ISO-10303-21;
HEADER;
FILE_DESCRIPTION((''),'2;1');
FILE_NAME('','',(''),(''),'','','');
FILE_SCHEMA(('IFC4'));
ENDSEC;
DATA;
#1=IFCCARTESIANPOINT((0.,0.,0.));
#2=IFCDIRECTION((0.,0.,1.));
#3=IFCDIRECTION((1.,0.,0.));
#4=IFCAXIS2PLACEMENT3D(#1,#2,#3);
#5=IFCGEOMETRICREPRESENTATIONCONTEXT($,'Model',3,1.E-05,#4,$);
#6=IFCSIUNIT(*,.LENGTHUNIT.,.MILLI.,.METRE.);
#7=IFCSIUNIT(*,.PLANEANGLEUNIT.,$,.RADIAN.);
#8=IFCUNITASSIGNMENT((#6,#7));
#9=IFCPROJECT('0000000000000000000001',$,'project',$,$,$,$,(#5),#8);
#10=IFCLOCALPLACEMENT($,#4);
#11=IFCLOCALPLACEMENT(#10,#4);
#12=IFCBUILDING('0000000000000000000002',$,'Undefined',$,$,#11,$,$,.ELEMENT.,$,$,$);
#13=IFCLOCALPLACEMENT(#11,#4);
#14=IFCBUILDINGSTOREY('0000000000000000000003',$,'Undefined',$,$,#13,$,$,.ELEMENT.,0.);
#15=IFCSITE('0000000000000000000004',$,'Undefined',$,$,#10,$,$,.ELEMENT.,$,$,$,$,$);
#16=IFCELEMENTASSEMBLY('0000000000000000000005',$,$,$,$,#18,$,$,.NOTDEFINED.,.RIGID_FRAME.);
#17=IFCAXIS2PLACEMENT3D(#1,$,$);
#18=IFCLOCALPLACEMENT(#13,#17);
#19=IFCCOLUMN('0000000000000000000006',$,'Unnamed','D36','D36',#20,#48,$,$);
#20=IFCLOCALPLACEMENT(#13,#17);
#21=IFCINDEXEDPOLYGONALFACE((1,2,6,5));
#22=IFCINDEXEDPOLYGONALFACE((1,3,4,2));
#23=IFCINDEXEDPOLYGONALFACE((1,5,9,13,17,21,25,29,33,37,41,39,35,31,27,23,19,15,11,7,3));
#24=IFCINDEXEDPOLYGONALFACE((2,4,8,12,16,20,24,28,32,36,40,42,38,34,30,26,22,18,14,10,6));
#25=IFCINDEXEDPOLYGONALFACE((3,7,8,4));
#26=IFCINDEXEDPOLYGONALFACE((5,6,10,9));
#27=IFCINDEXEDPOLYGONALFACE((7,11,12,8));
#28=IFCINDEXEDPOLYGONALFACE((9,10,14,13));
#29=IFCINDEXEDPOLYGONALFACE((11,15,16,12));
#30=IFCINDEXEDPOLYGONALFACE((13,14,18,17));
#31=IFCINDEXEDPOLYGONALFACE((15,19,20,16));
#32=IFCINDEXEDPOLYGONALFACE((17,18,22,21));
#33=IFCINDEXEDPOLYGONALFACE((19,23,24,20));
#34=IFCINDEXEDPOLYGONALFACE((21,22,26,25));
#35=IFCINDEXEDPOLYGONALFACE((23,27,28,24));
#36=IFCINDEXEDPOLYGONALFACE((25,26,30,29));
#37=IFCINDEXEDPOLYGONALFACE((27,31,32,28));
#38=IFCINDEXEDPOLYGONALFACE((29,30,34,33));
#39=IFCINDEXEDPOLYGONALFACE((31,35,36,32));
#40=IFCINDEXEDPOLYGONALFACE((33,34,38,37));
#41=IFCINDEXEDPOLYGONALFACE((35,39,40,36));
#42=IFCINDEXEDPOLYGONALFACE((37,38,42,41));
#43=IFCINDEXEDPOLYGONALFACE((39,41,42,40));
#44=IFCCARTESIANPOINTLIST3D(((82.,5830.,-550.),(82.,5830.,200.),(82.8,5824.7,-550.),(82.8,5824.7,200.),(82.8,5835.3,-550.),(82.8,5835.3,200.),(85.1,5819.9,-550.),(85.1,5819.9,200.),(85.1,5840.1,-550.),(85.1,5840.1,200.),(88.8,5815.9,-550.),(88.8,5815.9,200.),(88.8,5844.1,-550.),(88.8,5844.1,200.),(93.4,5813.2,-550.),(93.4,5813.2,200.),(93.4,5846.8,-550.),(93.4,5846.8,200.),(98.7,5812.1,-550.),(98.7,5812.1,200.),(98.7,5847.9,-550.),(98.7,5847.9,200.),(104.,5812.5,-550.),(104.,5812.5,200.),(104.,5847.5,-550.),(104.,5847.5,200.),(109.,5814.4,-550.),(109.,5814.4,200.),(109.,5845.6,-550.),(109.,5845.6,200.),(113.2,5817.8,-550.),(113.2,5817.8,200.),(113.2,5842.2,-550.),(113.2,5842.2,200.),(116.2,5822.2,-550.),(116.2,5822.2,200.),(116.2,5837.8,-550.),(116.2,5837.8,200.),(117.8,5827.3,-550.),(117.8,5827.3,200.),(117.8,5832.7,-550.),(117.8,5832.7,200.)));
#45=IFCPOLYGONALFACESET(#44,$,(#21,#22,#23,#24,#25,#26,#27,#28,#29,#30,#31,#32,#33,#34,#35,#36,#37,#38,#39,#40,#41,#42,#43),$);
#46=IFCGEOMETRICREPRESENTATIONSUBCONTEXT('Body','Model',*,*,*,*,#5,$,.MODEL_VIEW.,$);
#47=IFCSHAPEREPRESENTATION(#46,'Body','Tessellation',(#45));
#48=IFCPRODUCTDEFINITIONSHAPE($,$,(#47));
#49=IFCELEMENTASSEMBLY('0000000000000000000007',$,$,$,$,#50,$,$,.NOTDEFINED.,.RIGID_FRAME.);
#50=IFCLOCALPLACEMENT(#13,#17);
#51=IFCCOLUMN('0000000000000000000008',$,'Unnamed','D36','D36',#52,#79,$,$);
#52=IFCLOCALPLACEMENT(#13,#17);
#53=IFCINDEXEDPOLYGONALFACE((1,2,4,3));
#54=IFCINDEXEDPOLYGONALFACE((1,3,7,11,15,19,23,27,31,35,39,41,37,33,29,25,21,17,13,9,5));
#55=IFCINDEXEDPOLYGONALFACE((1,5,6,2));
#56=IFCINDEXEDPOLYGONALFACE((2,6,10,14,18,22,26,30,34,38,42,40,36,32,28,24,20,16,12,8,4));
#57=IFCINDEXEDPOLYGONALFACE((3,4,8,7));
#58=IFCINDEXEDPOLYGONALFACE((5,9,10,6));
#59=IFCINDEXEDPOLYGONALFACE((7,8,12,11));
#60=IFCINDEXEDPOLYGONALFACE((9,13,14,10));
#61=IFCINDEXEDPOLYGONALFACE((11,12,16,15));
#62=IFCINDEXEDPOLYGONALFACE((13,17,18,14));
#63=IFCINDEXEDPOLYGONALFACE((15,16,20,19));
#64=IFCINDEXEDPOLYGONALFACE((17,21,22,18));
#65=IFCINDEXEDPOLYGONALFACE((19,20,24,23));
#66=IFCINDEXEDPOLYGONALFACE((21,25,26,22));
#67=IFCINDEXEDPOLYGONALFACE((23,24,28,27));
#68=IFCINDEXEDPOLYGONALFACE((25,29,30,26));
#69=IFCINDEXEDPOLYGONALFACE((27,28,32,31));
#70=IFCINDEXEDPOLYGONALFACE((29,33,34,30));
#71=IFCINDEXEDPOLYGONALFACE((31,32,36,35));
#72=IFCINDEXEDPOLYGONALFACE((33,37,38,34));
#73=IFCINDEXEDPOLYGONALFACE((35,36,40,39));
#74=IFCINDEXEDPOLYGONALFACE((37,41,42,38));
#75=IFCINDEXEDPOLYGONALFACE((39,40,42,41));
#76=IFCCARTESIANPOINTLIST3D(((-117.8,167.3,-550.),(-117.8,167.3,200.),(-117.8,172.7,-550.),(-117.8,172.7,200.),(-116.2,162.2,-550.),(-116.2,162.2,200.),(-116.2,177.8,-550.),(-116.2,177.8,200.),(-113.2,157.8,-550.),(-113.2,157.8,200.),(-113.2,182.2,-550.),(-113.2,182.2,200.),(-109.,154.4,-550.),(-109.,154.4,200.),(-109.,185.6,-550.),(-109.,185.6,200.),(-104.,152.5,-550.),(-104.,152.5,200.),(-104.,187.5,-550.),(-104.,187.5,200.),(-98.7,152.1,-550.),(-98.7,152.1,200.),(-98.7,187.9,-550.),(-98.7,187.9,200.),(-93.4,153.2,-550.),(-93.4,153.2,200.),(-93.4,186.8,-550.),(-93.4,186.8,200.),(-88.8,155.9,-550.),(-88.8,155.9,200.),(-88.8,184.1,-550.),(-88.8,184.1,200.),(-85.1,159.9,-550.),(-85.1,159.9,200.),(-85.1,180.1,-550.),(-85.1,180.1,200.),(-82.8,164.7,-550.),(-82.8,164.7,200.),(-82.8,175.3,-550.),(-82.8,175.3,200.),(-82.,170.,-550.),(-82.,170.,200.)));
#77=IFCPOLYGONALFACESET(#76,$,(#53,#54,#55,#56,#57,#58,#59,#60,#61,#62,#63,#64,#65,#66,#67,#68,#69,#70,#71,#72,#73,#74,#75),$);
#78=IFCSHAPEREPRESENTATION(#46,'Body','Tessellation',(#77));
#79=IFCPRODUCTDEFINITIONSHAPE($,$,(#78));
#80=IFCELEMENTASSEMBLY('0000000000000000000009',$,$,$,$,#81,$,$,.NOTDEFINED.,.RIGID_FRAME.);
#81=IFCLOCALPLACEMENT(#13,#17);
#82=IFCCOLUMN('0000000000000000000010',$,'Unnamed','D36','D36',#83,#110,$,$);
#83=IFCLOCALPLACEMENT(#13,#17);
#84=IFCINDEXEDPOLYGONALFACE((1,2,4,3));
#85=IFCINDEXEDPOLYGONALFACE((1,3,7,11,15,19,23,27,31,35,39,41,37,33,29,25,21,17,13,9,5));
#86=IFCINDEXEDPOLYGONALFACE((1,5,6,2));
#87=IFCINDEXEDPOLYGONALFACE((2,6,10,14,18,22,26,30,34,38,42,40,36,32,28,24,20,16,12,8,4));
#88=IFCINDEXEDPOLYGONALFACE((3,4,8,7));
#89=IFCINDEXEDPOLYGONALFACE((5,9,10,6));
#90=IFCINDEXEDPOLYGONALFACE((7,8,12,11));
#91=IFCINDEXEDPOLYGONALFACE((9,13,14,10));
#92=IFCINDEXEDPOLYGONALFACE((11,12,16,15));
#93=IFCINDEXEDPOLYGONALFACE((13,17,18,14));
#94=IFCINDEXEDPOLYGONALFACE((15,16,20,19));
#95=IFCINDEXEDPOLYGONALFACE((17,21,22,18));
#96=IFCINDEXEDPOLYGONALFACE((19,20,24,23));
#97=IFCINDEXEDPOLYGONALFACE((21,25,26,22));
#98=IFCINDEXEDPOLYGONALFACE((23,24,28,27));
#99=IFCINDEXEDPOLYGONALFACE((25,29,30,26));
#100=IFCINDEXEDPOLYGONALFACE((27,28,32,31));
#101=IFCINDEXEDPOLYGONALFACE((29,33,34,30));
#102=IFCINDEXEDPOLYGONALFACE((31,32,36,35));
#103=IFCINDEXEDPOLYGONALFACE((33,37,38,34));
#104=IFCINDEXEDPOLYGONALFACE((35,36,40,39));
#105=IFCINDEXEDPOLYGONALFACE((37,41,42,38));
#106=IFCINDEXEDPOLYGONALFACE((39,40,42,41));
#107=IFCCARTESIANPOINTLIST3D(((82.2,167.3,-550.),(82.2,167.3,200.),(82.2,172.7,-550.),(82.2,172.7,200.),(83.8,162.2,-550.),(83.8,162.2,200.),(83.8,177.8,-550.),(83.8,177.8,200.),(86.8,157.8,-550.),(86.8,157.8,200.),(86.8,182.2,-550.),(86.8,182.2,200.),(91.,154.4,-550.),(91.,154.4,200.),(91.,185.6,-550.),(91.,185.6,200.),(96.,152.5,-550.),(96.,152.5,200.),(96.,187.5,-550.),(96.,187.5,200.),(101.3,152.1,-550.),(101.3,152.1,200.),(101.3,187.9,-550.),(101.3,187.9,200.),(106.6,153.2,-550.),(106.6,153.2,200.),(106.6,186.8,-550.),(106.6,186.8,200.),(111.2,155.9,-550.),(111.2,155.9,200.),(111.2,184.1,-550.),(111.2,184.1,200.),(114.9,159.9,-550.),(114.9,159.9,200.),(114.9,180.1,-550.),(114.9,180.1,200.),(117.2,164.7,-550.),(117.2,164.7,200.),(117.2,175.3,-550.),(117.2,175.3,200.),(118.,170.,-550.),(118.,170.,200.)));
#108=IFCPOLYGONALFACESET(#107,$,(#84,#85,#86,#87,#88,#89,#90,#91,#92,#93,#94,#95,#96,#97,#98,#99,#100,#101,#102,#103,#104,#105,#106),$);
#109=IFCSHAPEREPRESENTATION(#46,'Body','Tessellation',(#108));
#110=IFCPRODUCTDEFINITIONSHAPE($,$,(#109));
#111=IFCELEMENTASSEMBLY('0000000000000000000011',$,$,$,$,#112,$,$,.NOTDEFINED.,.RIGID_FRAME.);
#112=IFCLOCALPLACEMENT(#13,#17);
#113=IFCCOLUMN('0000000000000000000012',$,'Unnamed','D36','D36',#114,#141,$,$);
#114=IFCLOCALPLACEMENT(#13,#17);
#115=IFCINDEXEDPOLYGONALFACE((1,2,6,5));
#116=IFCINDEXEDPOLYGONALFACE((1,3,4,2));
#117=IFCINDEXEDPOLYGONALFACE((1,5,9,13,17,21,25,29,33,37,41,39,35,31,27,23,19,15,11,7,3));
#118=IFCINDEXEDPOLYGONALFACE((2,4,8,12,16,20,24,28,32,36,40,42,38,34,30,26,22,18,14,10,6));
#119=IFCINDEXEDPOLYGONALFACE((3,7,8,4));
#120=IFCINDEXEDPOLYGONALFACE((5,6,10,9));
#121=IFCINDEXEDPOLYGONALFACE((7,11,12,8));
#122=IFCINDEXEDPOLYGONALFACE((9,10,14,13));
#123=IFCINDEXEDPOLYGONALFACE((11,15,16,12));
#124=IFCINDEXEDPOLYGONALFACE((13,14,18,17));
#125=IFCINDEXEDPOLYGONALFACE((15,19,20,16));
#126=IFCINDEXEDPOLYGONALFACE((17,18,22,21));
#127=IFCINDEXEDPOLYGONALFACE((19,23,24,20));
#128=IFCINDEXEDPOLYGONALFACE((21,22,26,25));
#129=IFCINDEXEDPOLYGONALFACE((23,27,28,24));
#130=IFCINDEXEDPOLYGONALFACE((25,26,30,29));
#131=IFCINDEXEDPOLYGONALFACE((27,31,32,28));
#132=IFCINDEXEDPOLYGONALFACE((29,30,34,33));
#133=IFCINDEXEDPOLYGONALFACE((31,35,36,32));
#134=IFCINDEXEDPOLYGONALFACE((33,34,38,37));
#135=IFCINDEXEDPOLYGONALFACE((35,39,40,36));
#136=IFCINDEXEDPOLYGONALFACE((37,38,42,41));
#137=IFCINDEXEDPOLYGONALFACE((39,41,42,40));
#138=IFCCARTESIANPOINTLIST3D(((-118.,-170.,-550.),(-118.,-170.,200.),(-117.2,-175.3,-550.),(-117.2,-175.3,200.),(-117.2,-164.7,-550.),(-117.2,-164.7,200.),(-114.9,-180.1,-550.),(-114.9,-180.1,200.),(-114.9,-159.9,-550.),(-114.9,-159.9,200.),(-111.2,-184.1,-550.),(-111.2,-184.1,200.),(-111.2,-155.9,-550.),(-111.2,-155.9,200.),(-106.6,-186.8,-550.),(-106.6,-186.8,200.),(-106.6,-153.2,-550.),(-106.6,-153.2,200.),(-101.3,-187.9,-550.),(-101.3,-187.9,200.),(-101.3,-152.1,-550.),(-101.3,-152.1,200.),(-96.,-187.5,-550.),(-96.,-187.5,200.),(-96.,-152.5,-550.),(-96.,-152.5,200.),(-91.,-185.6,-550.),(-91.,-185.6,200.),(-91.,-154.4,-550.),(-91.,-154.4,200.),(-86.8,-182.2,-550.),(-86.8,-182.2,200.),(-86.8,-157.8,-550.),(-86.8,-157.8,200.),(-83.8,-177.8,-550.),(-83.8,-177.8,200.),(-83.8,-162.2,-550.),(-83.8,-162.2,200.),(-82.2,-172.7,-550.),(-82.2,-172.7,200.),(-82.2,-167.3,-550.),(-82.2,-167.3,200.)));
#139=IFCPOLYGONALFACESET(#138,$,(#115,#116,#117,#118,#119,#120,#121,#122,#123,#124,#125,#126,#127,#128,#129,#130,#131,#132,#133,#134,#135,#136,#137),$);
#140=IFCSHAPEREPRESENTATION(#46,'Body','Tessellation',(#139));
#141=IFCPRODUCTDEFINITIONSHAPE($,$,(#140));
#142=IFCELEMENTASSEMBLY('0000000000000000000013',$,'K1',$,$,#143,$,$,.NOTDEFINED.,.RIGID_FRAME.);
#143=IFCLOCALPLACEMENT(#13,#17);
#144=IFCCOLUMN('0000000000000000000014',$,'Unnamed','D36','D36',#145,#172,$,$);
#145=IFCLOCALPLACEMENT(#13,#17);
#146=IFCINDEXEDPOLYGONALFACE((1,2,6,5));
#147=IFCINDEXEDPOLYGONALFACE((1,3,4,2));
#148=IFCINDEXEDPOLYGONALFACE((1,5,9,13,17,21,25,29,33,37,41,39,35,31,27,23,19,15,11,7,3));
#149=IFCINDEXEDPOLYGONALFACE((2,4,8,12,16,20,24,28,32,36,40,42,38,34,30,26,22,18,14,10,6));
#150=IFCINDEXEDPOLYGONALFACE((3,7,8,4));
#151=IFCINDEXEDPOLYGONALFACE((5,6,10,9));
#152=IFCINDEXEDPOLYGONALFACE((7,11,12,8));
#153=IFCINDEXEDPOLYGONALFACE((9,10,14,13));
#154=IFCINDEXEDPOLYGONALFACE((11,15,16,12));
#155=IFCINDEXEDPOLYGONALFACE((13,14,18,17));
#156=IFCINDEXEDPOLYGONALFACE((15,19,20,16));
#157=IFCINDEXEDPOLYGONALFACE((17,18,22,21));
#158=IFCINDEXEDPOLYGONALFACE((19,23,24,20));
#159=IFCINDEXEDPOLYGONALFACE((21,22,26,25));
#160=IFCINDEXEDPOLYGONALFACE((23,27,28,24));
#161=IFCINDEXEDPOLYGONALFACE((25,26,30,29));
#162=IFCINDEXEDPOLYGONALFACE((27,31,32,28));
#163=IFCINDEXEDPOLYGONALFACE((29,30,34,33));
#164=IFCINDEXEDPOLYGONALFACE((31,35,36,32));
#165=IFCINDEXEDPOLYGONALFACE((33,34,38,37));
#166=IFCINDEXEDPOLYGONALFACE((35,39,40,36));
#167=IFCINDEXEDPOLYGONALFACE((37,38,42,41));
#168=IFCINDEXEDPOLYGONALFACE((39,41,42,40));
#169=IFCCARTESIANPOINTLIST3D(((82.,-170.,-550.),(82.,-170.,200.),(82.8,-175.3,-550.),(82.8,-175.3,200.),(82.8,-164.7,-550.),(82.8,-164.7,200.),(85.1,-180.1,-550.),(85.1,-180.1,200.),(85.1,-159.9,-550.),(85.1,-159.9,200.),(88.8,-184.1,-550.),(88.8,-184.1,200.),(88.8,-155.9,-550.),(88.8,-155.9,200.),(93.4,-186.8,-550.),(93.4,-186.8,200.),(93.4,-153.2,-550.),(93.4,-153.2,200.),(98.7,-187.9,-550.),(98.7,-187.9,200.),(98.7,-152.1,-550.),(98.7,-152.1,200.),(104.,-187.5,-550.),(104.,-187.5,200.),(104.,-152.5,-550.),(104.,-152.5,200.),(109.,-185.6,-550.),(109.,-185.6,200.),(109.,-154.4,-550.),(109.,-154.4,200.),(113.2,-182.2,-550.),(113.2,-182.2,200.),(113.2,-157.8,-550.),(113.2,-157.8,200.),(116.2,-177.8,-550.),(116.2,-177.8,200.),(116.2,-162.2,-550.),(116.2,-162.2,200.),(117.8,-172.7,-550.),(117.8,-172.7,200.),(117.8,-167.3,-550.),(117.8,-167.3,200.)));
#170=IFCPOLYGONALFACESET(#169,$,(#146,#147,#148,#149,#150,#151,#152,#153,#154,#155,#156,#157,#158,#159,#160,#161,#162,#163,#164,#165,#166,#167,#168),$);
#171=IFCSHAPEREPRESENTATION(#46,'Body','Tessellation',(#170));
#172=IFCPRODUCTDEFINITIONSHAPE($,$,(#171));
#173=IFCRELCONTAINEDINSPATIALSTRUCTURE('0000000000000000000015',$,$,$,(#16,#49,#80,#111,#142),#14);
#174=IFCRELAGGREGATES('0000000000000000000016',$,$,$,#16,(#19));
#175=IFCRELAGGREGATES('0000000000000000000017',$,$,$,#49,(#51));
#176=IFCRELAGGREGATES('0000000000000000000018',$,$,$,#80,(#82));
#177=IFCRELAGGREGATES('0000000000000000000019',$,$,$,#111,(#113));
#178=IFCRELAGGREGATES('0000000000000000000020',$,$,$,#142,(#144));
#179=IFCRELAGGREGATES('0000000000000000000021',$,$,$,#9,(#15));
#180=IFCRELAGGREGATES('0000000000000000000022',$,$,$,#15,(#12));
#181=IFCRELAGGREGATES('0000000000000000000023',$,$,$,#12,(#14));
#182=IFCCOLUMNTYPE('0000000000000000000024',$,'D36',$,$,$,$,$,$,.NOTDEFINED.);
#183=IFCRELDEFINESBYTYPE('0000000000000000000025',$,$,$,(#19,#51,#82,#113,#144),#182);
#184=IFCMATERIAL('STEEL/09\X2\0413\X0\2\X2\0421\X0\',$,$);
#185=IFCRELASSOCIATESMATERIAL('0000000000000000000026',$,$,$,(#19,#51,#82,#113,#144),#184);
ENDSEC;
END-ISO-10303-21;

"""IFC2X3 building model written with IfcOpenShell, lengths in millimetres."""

from ifc_helpers import new_model, si_unit, frame, origin_with_axes, origin_2d_with_axis, place, context, subcontext, project, spatial, circle, extrude, material, type_object, element, aggregate, save


model = new_model("IFC2X3")

# Units and contexts
model_context = context("Model", 3, precision=1e-05, world=origin_with_axes())
body_context = subcontext(model_context, "Body", "Model", "MODEL_VIEW")
ifc_project = project(units=[si_unit("LENGTHUNIT", "METRE", prefix="MILLI"), si_unit("PLANEANGLEUNIT", "RADIAN")], contexts=[model_context])

# Site, building, storey
site_placement = place(None, origin_with_axes())
site = spatial("IfcSite", under=ifc_project, at=site_placement, Name="Undefined", CompositionType="ELEMENT")
building_placement = place(site_placement, origin_with_axes())
building = spatial("IfcBuilding", under=site, at=building_placement, Name="Undefined", CompositionType="ELEMENT")
storey_placement = place(building_placement, origin_with_axes())
storey = spatial("IfcBuildingStorey", under=building, at=storey_placement, Name="Undefined", CompositionType="ELEMENT", Elevation=0.0)

# Element assemblies, columns
ifc_material_1 = material(Name="STEEL/09Г2С")
column_type_1 = type_object("IfcColumnType", Name="D36", PredefinedType="NOTDEFINED")
assembly_1_placement = place(storey_placement, origin_with_axes())
assembly_1 = element("IfcElementAssembly", 1, at=assembly_1_placement, inside=storey, AssemblyPlace="NOTDEFINED", PredefinedType="RIGID_FRAME")
column_1_placement = place(assembly_1_placement, frame((100.0, 5830.0, -550.0), z_axis=(0.0, 0.0, 1.0), x_axis=(0.0, 1.0, 0.0)))
column_1 = element("IfcColumn", 2, at=column_1_placement, type_object=column_type_1, material=ifc_material_1, Name="Unnamed", Description="D36", ObjectType="D36", context=body_context, shape_type="SweptSolid", body=[
    extrude(circle(Radius=18.0, at=origin_2d_with_axis()), frame((0.0, 0.0, 750.0), z_axis=(0.0, 0.0, -1.0), x_axis=(0.0, 1.0, 0.0)), (0.0, 0.0, 1.0), 750.0),
])
aggregate(assembly_1, [column_1])
assembly_2_placement = place(storey_placement, origin_with_axes())
assembly_2 = element("IfcElementAssembly", 3, at=assembly_2_placement, inside=storey, AssemblyPlace="NOTDEFINED", PredefinedType="RIGID_FRAME")
column_2_placement = place(assembly_2_placement, frame((-100.0, 170.0, -550.0), z_axis=(0.0, 0.0, 1.0), x_axis=(0.0, -1.0, 0.0)))
column_2 = element("IfcColumn", 4, at=column_2_placement, type_object=column_type_1, material=ifc_material_1, Name="Unnamed", Description="D36", ObjectType="D36", context=body_context, shape_type="SweptSolid", body=[
    extrude(circle(Radius=18.0, at=origin_2d_with_axis()), frame((0.0, 0.0, 750.0), z_axis=(0.0, 0.0, -1.0), x_axis=(0.0, 1.0, 0.0)), (0.0, 0.0, 1.0), 750.0),
])
aggregate(assembly_2, [column_2])
assembly_3_placement = place(storey_placement, origin_with_axes())
assembly_3 = element("IfcElementAssembly", 5, at=assembly_3_placement, inside=storey, AssemblyPlace="NOTDEFINED", PredefinedType="RIGID_FRAME")
column_3_placement = place(assembly_3_placement, frame((100.0, 170.0, -550.0), z_axis=(0.0, 0.0, 1.0), x_axis=(0.0, -1.0, 0.0)))
column_3 = element("IfcColumn", 6, at=column_3_placement, type_object=column_type_1, material=ifc_material_1, Name="Unnamed", Description="D36", ObjectType="D36", context=body_context, shape_type="SweptSolid", body=[
    extrude(circle(Radius=18.0, at=origin_2d_with_axis()), frame((0.0, 0.0, 750.0), z_axis=(0.0, 0.0, -1.0), x_axis=(0.0, 1.0, 0.0)), (0.0, 0.0, 1.0), 750.0),
])
aggregate(assembly_3, [column_3])
assembly_4_placement = place(storey_placement, origin_with_axes())
assembly_4 = element("IfcElementAssembly", 7, at=assembly_4_placement, inside=storey, AssemblyPlace="NOTDEFINED", PredefinedType="RIGID_FRAME")
column_4_placement = place(assembly_4_placement, frame((-100.0, -170.0, -550.0), z_axis=(0.0, 0.0, 1.0), x_axis=(0.0, 1.0, 0.0)))
column_4 = element("IfcColumn", 8, at=column_4_placement, type_object=column_type_1, material=ifc_material_1, Name="Unnamed", Description="D36", ObjectType="D36", context=body_context, shape_type="SweptSolid", body=[
    extrude(circle(Radius=18.0, at=origin_2d_with_axis()), frame((0.0, 0.0, 750.0), z_axis=(0.0, 0.0, -1.0), x_axis=(0.0, 1.0, 0.0)), (0.0, 0.0, 1.0), 750.0),
])
aggregate(assembly_4, [column_4])
assembly_5_placement = place(storey_placement, origin_with_axes())
assembly_5 = element("IfcElementAssembly", 9, at=assembly_5_placement, inside=storey, Name="K1", AssemblyPlace="NOTDEFINED", PredefinedType="RIGID_FRAME")
column_5_placement = place(assembly_5_placement, frame((100.0, -170.0, -550.0), z_axis=(0.0, 0.0, 1.0), x_axis=(0.0, 1.0, 0.0)))
column_5 = element("IfcColumn", 10, at=column_5_placement, type_object=column_type_1, material=ifc_material_1, Name="Unnamed", Description="D36", ObjectType="D36", context=body_context, shape_type="SweptSolid", body=[
    extrude(circle(Radius=18.0, at=origin_2d_with_axis()), frame((0.0, 0.0, 750.0), z_axis=(0.0, 0.0, -1.0), x_axis=(0.0, 1.0, 0.0)), (0.0, 0.0, 1.0), 750.0),
])
aggregate(assembly_5, [column_5])

save(model, "model.ifc")
